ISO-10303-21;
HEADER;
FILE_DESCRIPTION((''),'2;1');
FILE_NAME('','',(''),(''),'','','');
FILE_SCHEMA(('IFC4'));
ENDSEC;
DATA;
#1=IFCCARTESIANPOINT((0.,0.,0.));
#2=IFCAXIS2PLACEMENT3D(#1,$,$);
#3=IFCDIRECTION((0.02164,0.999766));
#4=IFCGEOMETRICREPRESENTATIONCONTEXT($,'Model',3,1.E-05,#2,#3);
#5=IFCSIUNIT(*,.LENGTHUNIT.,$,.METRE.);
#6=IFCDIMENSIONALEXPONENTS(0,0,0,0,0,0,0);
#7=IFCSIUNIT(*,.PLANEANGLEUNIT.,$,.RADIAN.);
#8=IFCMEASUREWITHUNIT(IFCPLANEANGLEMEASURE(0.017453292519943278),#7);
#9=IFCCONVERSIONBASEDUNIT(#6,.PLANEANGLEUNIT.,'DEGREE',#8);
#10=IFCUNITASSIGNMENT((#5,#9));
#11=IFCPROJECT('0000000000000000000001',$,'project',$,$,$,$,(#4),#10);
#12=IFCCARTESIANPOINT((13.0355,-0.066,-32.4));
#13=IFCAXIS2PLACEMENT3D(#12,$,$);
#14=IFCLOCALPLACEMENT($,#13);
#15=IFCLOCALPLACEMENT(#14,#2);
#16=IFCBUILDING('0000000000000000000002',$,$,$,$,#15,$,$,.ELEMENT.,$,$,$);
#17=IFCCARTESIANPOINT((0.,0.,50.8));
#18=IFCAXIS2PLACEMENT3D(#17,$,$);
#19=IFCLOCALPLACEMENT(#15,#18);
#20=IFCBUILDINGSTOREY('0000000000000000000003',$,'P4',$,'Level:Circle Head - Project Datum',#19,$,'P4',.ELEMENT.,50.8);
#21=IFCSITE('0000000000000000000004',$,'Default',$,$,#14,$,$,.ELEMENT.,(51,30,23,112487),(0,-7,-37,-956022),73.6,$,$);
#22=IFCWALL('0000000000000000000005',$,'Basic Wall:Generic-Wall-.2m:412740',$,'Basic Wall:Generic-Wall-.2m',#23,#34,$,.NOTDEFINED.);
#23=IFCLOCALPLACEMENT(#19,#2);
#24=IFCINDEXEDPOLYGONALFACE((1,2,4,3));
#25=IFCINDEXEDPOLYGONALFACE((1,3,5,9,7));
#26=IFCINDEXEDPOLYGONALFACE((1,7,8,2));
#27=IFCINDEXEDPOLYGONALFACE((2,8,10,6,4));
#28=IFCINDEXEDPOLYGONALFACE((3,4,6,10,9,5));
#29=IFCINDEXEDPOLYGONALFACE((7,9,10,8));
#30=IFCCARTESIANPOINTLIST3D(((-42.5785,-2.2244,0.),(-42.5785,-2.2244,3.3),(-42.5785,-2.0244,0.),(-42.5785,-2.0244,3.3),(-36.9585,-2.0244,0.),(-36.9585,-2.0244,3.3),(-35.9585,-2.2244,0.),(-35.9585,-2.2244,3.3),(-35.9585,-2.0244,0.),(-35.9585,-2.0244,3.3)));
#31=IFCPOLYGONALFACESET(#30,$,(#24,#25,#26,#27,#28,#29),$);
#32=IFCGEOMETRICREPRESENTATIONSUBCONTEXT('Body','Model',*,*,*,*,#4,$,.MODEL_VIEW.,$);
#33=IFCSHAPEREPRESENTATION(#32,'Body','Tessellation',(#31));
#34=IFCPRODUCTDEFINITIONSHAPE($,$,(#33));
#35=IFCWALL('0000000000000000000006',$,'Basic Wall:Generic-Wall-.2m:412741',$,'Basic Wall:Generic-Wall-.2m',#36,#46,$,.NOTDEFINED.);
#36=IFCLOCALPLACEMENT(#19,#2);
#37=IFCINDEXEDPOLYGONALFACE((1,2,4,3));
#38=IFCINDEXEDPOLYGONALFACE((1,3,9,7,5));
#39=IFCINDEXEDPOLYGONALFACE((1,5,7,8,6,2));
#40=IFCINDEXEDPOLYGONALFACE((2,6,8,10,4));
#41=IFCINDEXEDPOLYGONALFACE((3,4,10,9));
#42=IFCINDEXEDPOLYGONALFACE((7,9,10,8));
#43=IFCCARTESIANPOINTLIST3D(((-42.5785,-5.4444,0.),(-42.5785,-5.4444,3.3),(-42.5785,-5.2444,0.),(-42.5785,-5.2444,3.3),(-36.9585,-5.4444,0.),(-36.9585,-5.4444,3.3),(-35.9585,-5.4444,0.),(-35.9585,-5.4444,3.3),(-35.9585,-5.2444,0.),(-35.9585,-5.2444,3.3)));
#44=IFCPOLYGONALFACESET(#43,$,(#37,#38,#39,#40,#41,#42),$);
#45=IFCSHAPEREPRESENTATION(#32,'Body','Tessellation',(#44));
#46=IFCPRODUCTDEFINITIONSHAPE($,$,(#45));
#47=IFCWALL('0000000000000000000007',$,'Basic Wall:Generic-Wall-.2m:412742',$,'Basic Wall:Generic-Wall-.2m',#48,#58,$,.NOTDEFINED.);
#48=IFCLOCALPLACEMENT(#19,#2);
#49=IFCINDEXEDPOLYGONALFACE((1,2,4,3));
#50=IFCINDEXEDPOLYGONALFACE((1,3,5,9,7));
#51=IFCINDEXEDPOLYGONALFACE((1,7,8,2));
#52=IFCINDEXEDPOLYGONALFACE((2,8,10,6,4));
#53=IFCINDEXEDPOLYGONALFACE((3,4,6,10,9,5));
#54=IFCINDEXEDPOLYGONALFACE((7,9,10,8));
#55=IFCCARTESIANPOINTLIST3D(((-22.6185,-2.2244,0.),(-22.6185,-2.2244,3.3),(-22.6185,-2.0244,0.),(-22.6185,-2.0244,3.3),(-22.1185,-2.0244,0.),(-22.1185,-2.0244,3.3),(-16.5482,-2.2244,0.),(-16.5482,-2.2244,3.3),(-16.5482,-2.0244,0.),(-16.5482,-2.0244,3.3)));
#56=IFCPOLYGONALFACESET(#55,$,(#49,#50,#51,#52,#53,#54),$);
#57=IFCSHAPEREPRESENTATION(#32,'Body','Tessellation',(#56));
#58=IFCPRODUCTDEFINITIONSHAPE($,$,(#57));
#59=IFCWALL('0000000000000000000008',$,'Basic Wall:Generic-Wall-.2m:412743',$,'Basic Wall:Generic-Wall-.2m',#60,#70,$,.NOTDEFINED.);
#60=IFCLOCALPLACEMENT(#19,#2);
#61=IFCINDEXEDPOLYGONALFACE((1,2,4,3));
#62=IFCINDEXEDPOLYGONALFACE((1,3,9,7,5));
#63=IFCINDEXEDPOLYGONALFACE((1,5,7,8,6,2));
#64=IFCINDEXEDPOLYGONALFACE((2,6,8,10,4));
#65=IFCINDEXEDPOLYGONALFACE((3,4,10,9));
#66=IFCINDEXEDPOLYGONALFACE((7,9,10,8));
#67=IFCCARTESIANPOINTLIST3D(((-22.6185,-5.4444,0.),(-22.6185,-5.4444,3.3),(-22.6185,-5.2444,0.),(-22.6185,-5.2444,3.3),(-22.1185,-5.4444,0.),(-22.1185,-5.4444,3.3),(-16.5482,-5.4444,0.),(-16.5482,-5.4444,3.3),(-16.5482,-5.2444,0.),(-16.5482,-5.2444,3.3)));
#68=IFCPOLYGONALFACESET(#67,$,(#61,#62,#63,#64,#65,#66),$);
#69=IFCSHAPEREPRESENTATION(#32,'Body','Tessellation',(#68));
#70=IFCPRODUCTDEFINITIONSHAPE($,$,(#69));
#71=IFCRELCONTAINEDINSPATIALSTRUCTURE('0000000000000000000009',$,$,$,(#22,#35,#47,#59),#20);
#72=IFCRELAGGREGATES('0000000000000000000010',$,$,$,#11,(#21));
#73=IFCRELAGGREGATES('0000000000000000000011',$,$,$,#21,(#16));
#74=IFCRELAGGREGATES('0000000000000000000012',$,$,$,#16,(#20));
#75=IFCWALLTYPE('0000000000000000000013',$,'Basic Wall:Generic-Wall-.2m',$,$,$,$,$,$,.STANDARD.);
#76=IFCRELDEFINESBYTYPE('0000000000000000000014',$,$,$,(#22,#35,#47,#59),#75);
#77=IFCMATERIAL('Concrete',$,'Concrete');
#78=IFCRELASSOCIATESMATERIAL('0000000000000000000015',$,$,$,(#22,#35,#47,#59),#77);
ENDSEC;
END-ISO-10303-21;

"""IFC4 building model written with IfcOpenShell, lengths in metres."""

from ifc_helpers import new_model, entity, si_unit, converted_unit, direction, frame, origin, place, context, subcontext, project, spatial, indexed_curve, outline, extrude, material, type_object, element, save


model = new_model("IFC4")

# Units and contexts
model_context = context("Model", 3, precision=1e-05, world=origin(), true_north=direction((0.02164, 0.999766)))
body_context = subcontext(model_context, "Body", "Model", "MODEL_VIEW")
ifc_project = project(units=[si_unit("LENGTHUNIT", "METRE"), converted_unit("PLANEANGLEUNIT", "DEGREE", entity("IfcPlaneAngleMeasure", 0.017453292519943278), si_unit("PLANEANGLEUNIT", "RADIAN"), dimensions=[0, 0, 0, 0, 0, 0, 0])], contexts=[model_context])

# Site, building, storey
site_placement = place(None, frame((13.0355, -0.066, -32.4)))
site = spatial("IfcSite", under=ifc_project, at=site_placement, Name="Default", CompositionType="ELEMENT", RefLatitude=(51, 30, 23, 112487), RefLongitude=(0, -7, -37, -956022), RefElevation=73.6)
building_placement = place(site_placement, origin())
building = spatial("IfcBuilding", under=site, at=building_placement, CompositionType="ELEMENT")
storey_placement = place(building_placement, frame((0.0, 0.0, 50.8)))
storey = spatial("IfcBuildingStorey", under=building, at=storey_placement, Name="P4", ObjectType="Level:Circle Head - Project Datum", LongName="P4", CompositionType="ELEMENT", Elevation=50.8)

# Shared definitions
ifc_material = material(Name="Concrete", Category="Concrete")

# Walls
wall_type_1 = type_object("IfcWallType", Name="Basic Wall:Generic-Wall-.2m", PredefinedType="STANDARD")
wall_1_placement = place(storey_placement, frame((-35.9585, -2.1244, 0.0), z_axis=(0.0, 0.0, 1.0), x_axis=(-1.0, 0.0, 0.0)))
element("IfcWall", 1, at=wall_1_placement, inside=storey, type_object=wall_type_1, material=ifc_material, Name="Basic Wall:Generic-Wall-.2m:412740", ObjectType="Basic Wall:Generic-Wall-.2m", PredefinedType="NOTDEFINED", context=body_context, shape_type="SweptSolid", body=[
    extrude(outline(indexed_curve([(6.6201, -0.1), (6.6201, 0.1), (0.0, 0.1), (0.0, -0.1), (1.0, -0.1), (6.6201, -0.1)], self_intersect=False)), origin(), (0.0, 0.0, 1.0), 3.3),
])
wall_2_placement = place(storey_placement, frame((-35.9585, -5.3444, 0.0), z_axis=(0.0, 0.0, 1.0), x_axis=(-1.0, 0.0, 0.0)))
element("IfcWall", 2, at=wall_2_placement, inside=storey, type_object=wall_type_1, material=ifc_material, Name="Basic Wall:Generic-Wall-.2m:412741", ObjectType="Basic Wall:Generic-Wall-.2m", PredefinedType="NOTDEFINED", context=body_context, shape_type="SweptSolid", body=[
    extrude(outline(indexed_curve([(6.62, -0.1), (6.62, 0.1), (1.0, 0.1), (0.0, 0.1), (0.0, -0.1), (6.62, -0.1)], self_intersect=False)), origin(), (0.0, 0.0, 1.0), 3.3),
])
wall_3_placement = place(storey_placement, frame((-22.6185, -2.1244, 0.0)))
element("IfcWall", 3, at=wall_3_placement, inside=storey, type_object=wall_type_1, material=ifc_material, Name="Basic Wall:Generic-Wall-.2m:412742", ObjectType="Basic Wall:Generic-Wall-.2m", PredefinedType="NOTDEFINED", context=body_context, shape_type="SweptSolid", body=[
    extrude(outline(indexed_curve([(6.0702, -0.1), (6.0702, 0.1), (0.5, 0.1), (0.0, 0.1), (0.0, -0.1), (6.0702, -0.1)], self_intersect=False)), origin(), (0.0, 0.0, 1.0), 3.3),
])
wall_4_placement = place(storey_placement, frame((-22.6185, -5.3444, 0.0)))
element("IfcWall", 4, at=wall_4_placement, inside=storey, type_object=wall_type_1, material=ifc_material, Name="Basic Wall:Generic-Wall-.2m:412743", ObjectType="Basic Wall:Generic-Wall-.2m", PredefinedType="NOTDEFINED", context=body_context, shape_type="SweptSolid", body=[
    extrude(outline(indexed_curve([(6.0702, -0.1), (6.0702, 0.1), (0.0, 0.1), (0.0, -0.1), (0.5, -0.1), (6.0702, -0.1)], self_intersect=False)), origin(), (0.0, 0.0, 1.0), 3.3),
])

save(model, "model.ifc")
